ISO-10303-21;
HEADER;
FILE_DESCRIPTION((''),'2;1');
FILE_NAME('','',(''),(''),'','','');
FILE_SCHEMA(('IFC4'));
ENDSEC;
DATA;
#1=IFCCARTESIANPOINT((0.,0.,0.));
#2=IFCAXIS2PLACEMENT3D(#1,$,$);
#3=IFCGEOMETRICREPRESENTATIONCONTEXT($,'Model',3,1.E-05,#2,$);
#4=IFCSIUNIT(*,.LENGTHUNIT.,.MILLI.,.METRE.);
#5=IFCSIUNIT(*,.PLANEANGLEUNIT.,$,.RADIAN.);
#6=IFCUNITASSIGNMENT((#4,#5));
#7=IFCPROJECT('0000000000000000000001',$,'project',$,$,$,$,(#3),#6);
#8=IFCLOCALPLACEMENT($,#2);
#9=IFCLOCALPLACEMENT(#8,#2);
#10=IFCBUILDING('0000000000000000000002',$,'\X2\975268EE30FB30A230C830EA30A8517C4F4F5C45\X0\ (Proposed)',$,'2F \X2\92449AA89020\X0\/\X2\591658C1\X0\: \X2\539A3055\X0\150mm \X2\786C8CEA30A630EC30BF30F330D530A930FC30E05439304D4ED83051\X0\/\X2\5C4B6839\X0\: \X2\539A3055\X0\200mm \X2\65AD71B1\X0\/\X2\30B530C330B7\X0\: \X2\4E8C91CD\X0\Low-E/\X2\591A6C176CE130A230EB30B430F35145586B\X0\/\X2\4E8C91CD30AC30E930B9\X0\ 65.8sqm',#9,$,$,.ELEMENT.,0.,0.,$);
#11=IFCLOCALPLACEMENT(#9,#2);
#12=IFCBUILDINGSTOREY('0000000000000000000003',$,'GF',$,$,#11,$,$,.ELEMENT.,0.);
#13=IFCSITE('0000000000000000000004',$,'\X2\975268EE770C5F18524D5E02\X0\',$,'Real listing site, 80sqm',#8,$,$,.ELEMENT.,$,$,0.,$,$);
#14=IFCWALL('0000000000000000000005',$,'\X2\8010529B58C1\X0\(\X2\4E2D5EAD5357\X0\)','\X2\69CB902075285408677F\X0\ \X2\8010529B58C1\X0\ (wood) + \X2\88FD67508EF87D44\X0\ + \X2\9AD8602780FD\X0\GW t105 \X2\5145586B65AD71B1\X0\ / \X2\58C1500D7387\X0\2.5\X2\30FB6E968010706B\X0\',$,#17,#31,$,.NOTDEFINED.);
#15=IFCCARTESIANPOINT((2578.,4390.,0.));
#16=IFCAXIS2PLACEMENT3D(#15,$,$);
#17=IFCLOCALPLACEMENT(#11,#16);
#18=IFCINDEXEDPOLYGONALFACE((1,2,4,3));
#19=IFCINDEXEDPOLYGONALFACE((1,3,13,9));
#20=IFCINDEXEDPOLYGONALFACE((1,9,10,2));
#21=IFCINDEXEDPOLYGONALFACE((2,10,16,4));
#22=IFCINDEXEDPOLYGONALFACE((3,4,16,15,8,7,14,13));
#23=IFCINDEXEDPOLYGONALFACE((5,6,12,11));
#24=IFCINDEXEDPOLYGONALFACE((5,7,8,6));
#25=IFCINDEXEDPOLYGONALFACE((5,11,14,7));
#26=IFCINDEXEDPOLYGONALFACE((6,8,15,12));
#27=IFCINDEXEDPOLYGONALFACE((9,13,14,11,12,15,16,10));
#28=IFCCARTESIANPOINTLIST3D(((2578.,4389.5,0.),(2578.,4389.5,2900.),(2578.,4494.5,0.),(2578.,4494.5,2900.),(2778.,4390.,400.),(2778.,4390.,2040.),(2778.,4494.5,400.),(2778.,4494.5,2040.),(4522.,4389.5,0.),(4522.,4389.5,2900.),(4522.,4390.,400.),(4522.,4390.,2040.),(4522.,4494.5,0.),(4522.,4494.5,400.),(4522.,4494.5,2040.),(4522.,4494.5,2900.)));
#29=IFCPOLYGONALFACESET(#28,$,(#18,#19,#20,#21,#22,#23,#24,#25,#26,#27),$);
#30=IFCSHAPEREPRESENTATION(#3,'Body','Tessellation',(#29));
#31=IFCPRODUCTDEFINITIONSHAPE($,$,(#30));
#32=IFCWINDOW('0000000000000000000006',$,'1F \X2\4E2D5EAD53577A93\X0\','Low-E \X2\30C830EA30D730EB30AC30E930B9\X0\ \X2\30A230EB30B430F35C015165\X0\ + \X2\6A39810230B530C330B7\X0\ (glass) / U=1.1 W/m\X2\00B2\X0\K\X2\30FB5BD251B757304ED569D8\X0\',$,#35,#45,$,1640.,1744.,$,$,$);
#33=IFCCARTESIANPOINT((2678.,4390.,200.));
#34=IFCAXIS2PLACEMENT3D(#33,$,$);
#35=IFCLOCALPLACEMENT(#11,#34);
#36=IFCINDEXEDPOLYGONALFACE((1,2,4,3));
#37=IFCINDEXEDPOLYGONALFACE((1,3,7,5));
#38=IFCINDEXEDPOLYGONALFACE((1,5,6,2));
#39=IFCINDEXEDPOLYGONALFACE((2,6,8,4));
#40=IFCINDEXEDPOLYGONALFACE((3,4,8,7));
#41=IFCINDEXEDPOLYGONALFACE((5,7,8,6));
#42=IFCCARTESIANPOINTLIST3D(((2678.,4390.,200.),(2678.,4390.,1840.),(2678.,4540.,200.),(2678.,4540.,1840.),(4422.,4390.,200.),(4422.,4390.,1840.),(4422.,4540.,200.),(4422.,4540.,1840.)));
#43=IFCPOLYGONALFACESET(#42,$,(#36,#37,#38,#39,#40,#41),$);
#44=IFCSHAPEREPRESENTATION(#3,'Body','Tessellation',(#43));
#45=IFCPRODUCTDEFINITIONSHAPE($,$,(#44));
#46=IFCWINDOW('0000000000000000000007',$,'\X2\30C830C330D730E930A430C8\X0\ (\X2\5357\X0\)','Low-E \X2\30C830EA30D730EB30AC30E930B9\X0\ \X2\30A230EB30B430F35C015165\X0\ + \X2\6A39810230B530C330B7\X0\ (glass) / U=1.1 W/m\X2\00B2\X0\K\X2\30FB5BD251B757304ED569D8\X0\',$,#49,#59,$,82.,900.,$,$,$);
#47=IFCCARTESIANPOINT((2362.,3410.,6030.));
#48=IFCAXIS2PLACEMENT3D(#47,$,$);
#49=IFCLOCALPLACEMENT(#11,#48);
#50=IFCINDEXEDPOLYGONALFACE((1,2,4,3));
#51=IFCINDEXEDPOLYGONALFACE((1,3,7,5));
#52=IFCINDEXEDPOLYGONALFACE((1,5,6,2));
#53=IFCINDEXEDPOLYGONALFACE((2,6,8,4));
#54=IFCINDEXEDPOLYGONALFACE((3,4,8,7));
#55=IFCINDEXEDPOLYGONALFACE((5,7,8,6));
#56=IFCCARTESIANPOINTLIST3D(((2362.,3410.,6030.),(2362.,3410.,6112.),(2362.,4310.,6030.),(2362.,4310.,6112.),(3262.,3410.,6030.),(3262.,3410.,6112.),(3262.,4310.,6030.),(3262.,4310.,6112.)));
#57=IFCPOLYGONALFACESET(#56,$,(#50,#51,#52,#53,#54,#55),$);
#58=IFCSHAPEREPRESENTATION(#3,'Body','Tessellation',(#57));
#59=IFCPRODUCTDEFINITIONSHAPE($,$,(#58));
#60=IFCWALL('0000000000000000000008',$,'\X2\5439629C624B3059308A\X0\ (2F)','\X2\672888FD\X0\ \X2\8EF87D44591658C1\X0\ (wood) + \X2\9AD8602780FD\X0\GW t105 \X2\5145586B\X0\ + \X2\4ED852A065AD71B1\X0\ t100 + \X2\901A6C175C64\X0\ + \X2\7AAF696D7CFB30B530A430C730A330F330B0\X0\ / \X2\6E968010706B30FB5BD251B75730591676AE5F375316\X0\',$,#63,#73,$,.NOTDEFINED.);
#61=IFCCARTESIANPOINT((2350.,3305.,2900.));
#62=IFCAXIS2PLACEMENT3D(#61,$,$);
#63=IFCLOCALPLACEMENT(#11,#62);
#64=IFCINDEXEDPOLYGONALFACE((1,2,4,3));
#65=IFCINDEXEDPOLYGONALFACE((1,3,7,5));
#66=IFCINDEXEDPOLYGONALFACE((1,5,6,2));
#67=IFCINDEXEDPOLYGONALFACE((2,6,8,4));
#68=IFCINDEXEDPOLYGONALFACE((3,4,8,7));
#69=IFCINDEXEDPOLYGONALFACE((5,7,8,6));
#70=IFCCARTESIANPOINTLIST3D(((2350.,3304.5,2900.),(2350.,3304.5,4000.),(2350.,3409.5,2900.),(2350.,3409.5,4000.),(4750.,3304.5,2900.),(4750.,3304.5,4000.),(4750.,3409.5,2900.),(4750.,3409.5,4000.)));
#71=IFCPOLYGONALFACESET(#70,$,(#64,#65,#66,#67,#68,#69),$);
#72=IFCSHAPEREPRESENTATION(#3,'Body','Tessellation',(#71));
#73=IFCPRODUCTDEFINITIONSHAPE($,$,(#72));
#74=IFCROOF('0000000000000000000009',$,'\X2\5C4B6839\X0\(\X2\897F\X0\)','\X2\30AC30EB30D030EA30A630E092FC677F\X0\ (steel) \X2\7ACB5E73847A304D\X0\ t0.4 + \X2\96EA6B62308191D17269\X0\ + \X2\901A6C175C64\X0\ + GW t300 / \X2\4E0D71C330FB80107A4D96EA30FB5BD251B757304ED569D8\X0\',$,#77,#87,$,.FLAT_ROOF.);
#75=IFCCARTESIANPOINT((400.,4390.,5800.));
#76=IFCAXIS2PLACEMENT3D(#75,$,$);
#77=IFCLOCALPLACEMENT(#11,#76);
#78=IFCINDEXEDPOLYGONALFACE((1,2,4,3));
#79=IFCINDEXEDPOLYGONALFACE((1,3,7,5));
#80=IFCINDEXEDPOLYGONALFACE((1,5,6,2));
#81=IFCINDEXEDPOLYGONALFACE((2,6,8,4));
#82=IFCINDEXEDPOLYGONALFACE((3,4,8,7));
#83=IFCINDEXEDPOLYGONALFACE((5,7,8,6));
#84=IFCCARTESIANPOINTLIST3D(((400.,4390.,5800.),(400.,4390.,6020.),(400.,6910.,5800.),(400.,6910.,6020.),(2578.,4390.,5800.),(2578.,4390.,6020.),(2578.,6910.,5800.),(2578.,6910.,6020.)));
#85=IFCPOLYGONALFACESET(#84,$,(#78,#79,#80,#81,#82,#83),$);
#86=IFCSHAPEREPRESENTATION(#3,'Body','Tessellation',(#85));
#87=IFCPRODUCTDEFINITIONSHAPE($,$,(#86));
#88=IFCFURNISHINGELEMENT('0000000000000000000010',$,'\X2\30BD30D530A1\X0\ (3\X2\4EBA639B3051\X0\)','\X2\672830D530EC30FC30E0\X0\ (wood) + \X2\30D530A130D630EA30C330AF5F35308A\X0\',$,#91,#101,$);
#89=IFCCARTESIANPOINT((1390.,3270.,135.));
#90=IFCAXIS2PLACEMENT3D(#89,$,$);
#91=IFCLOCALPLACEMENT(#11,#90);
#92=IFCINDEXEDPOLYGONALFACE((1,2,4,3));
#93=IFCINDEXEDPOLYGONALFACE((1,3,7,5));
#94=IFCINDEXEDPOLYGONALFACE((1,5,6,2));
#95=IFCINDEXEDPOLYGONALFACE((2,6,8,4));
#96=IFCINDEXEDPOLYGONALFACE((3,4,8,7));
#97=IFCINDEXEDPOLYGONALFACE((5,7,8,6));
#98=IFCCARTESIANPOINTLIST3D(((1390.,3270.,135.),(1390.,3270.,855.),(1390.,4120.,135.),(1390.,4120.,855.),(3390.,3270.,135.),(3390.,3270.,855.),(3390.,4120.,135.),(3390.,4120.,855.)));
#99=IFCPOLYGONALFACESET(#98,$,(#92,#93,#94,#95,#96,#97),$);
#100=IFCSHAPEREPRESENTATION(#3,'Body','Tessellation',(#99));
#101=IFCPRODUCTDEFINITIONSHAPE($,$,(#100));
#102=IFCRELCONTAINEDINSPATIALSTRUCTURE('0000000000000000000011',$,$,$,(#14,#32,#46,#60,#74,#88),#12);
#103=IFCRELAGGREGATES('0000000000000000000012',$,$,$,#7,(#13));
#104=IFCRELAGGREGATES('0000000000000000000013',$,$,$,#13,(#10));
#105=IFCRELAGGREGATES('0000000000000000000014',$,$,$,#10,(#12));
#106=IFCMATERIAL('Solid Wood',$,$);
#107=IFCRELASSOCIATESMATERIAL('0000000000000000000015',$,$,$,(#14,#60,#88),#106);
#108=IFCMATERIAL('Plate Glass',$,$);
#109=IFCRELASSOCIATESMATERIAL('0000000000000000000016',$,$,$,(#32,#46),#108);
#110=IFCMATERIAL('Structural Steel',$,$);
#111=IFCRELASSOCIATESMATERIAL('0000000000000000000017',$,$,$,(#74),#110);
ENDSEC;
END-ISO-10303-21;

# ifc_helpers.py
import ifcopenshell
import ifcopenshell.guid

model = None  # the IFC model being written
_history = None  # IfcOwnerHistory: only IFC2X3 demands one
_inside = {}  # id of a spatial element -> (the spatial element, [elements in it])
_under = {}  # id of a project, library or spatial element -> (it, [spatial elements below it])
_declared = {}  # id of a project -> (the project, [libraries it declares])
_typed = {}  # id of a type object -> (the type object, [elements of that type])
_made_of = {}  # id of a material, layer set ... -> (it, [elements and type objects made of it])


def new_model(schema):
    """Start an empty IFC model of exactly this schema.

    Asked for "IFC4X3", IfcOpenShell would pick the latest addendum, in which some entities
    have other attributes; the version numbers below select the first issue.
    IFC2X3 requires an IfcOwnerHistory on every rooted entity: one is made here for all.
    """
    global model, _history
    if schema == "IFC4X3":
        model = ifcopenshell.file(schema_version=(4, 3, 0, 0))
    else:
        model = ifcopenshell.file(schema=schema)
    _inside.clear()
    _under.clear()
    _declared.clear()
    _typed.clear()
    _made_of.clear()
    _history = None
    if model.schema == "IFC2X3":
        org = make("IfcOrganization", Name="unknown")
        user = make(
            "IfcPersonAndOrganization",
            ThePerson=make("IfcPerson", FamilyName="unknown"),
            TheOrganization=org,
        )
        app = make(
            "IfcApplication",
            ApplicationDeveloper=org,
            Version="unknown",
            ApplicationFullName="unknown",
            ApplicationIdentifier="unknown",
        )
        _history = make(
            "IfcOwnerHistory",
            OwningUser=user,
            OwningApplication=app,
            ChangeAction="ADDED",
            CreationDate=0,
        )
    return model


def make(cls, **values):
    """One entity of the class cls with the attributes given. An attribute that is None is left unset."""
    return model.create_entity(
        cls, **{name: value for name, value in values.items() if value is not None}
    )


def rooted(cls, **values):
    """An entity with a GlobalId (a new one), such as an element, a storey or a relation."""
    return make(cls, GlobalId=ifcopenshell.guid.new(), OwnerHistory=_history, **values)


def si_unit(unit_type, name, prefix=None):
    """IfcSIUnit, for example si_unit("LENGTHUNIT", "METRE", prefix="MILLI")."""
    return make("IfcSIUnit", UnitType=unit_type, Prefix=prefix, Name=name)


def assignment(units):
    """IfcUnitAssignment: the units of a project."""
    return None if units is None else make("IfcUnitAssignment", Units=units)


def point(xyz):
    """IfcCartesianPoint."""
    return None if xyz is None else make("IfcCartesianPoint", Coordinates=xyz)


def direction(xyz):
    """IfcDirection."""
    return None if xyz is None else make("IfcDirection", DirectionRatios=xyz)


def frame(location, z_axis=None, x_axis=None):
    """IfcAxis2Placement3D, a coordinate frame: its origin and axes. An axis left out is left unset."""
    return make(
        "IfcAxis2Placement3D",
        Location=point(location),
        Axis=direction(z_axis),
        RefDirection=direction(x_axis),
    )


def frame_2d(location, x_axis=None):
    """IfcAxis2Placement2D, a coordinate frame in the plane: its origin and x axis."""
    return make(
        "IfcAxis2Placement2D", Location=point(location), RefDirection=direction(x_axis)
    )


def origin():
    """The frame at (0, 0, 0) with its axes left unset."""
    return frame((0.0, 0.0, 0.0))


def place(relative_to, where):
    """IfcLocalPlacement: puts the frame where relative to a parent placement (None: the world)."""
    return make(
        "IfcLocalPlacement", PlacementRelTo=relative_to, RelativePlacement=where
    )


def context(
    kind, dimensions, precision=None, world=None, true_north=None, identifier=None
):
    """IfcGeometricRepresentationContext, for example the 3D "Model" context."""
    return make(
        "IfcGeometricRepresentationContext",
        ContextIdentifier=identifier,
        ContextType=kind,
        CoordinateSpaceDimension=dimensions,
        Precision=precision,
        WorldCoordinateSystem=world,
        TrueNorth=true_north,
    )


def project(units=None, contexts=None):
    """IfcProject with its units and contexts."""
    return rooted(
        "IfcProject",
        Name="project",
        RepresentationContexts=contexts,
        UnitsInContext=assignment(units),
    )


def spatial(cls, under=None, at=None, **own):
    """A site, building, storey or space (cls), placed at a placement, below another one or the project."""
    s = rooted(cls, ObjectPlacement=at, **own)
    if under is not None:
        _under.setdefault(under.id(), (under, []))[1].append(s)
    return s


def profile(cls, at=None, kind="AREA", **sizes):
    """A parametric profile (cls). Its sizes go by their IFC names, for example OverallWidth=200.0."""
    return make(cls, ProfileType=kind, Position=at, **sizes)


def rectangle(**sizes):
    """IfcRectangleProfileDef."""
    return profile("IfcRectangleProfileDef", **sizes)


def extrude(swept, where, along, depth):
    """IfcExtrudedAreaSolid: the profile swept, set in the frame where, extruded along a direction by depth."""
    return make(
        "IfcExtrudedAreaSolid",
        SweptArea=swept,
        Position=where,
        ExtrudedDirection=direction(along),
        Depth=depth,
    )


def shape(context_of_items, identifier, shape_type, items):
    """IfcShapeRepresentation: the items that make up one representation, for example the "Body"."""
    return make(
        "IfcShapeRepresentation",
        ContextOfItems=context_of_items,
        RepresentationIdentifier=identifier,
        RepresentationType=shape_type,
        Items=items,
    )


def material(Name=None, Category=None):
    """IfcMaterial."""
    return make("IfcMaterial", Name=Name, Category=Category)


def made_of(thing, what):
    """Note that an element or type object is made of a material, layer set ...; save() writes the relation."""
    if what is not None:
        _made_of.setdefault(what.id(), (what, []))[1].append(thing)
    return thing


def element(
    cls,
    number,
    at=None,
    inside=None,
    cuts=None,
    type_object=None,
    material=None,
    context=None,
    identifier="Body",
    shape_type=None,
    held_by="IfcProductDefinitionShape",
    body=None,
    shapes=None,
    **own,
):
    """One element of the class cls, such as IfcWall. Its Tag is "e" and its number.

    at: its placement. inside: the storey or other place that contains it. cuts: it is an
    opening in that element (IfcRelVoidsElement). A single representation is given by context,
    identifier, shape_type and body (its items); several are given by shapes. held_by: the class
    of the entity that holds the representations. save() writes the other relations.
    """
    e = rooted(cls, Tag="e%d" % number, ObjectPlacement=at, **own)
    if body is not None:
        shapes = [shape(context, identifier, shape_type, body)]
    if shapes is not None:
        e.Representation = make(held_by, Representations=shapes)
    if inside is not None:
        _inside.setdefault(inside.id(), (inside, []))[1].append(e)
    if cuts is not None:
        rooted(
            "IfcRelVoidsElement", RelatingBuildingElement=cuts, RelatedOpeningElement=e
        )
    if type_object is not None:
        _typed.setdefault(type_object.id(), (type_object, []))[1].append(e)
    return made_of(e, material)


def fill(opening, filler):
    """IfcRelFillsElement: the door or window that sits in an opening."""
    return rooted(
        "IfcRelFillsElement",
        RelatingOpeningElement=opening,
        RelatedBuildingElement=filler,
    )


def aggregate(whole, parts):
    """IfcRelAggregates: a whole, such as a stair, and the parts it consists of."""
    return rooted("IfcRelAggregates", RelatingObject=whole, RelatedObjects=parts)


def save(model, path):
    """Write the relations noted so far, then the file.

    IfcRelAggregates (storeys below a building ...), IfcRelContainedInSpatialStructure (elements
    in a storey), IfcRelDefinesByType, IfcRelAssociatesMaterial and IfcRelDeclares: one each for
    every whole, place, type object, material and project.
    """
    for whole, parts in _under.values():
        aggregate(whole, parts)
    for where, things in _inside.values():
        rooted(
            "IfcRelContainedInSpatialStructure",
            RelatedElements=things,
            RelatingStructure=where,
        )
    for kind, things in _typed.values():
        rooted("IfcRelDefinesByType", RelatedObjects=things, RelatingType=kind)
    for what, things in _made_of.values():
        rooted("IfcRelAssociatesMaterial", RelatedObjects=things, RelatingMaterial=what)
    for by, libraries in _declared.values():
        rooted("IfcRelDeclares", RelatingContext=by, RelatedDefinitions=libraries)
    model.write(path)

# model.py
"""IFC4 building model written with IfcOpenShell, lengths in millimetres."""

from ifc_helpers import new_model, si_unit, frame, frame_2d, origin, place, context, project, spatial, rectangle, extrude, material, element, fill, save


model = new_model("IFC4")

# Units and contexts
model_context = context("Model", 3, precision=1e-05, world=origin())
ifc_project = project(units=[si_unit("LENGTHUNIT", "METRE", prefix="MILLI"), si_unit("PLANEANGLEUNIT", "RADIAN")], contexts=[model_context])

# Site, building, storey
site_placement = place(None, origin())
site = spatial("IfcSite", under=ifc_project, at=site_placement, Name="青森県弘前市", ObjectType="Real listing site, 80sqm", CompositionType="ELEMENT", RefElevation=0.0)
building_placement = place(site_placement, origin())
building = spatial("IfcBuilding", under=site, at=building_placement, Name="青森・アトリエ兼住居 (Proposed)", ObjectType="2F 鉄骨造/外壁: 厚さ150mm 硬質ウレタンフォーム吹き付け/屋根: 厚さ200mm 断熱/サッシ: 二重Low-E/多気泡アルゴン充填/二重ガラス 65.8sqm", CompositionType="ELEMENT", ElevationOfRefHeight=0.0, ElevationOfTerrain=0.0)
storey_placement = place(building_placement, origin())
storey = spatial("IfcBuildingStorey", under=building, at=storey_placement, Name="GF", CompositionType="ELEMENT", Elevation=0.0)

# Shared definitions
ifc_material_1 = material(Name="Solid Wood")

# Wall, opening, window
wall_1_placement = place(storey_placement, frame((2578.0, 4390.0, 0.0)))
wall_1 = element("IfcWall", 1, at=wall_1_placement, inside=storey, material=ifc_material_1, Name="耐力壁(中庭南)", Description="構造用合板 耐力壁 (wood) + 製材軸組 + 高性能GW t105 充填断熱 / 壁倍率2.5・準耐火", PredefinedType="NOTDEFINED", context=model_context, shape_type="SweptSolid", body=[
    extrude(rectangle(XDim=1944.0, YDim=105.0, at=frame_2d((972.0, 52.0))), frame((2578.0, 4390.0, 0.0)), (0.0, 0.0, 1.0), 2900.0),
])
opening_placement = place(storey_placement, frame((2678.0, 4390.0, 200.0)))
opening = element("IfcOpeningElement", 2, at=opening_placement, cuts=wall_1, PredefinedType="NOTDEFINED", context=model_context, shape_type="SweptSolid", body=[
    extrude(rectangle(XDim=1744.0, YDim=150.0, at=frame_2d((872.0, 75.0))), frame((2678.0, 4390.0, 200.0)), (0.0, 0.0, 1.0), 1640.0),
])
ifc_material_2 = material(Name="Plate Glass")
window_1_placement = place(storey_placement, frame((2678.0, 4390.0, 200.0)))
window_1 = element("IfcWindow", 3, at=window_1_placement, inside=storey, material=ifc_material_2, Name="1F 中庭南窓", Description="Low-E トリプルガラス アルゴン封入 + 樹脂サッシ (glass) / U=1.1 W/m²K・寒冷地仕様", OverallHeight=1640.0, OverallWidth=1744.0, context=model_context, shape_type="SweptSolid", body=[
    extrude(rectangle(XDim=1744.0, YDim=150.0, at=frame_2d((872.0, 75.0))), frame((2678.0, 4390.0, 200.0)), (0.0, 0.0, 1.0), 1640.0),
])
fill(opening, window_1)

# Window
window_2_placement = place(storey_placement, frame((2362.0, 3410.0, 6030.0)))
element("IfcWindow", 4, at=window_2_placement, inside=storey, material=ifc_material_2, Name="トップライト (南)", Description="Low-E トリプルガラス アルゴン封入 + 樹脂サッシ (glass) / U=1.1 W/m²K・寒冷地仕様", OverallHeight=82.0, OverallWidth=900.0, context=model_context, shape_type="SweptSolid", body=[
    extrude(rectangle(XDim=900.0, YDim=900.0, at=frame_2d((450.0, 450.0))), frame((2362.0, 3410.0, 6030.0)), (0.0, 0.0, 1.0), 82.0),
])

# Wall
wall_2_placement = place(storey_placement, frame((2350.0, 3305.0, 2900.0)))
element("IfcWall", 5, at=wall_2_placement, inside=storey, material=ifc_material_1, Name="吹抜手すり (2F)", Description="木製 軸組外壁 (wood) + 高性能GW t105 充填 + 付加断熱 t100 + 通気層 + 窯業系サイディング / 準耐火・寒冷地外皮強化", PredefinedType="NOTDEFINED", context=model_context, shape_type="SweptSolid", body=[
    extrude(rectangle(XDim=2400.0, YDim=105.0, at=frame_2d((1200.0, 52.0))), frame((2350.0, 3305.0, 2900.0)), (0.0, 0.0, 1.0), 1100.0),
])

# Roof
ifc_material_3 = material(Name="Structural Steel")
for number, where, name in (
    (6, (400.0, 4390.0, 5800.0), "屋根(西)"),
):
    element("IfcRoof", number, at=place(storey_placement, frame(where)), inside=storey, material=ifc_material_3, Name=name, Description="ガルバリウム鋼板 (steel) 立平葺き t0.4 + 雪止め金物 + 通気層 + GW t300 / 不燃・耐積雪・寒冷地仕様", PredefinedType="FLAT_ROOF", context=model_context, shape_type="SweptSolid", body=[
        extrude(rectangle(XDim=2178.0, YDim=2520.0, at=frame_2d((1089.0, 1260.0))), frame((400.0, 4390.0, 5800.0)), (0.0, 0.0, 1.0), 220.0),
    ])

# Furnishing element
furnishing_placement = place(storey_placement, frame((1390.0, 3270.0, 135.0)))
element("IfcFurnishingElement", 7, at=furnishing_placement, inside=storey, material=ifc_material_1, Name="ソファ (3人掛け)", Description="木フレーム (wood) + ファブリック張り", context=model_context, shape_type="SweptSolid", body=[
    extrude(rectangle(XDim=2000.0, YDim=850.0, at=frame_2d((1000.0, 425.0))), frame((1390.0, 3270.0, 135.0)), (0.0, 0.0, 1.0), 720.0),
])

save(model, "model.ifc")
